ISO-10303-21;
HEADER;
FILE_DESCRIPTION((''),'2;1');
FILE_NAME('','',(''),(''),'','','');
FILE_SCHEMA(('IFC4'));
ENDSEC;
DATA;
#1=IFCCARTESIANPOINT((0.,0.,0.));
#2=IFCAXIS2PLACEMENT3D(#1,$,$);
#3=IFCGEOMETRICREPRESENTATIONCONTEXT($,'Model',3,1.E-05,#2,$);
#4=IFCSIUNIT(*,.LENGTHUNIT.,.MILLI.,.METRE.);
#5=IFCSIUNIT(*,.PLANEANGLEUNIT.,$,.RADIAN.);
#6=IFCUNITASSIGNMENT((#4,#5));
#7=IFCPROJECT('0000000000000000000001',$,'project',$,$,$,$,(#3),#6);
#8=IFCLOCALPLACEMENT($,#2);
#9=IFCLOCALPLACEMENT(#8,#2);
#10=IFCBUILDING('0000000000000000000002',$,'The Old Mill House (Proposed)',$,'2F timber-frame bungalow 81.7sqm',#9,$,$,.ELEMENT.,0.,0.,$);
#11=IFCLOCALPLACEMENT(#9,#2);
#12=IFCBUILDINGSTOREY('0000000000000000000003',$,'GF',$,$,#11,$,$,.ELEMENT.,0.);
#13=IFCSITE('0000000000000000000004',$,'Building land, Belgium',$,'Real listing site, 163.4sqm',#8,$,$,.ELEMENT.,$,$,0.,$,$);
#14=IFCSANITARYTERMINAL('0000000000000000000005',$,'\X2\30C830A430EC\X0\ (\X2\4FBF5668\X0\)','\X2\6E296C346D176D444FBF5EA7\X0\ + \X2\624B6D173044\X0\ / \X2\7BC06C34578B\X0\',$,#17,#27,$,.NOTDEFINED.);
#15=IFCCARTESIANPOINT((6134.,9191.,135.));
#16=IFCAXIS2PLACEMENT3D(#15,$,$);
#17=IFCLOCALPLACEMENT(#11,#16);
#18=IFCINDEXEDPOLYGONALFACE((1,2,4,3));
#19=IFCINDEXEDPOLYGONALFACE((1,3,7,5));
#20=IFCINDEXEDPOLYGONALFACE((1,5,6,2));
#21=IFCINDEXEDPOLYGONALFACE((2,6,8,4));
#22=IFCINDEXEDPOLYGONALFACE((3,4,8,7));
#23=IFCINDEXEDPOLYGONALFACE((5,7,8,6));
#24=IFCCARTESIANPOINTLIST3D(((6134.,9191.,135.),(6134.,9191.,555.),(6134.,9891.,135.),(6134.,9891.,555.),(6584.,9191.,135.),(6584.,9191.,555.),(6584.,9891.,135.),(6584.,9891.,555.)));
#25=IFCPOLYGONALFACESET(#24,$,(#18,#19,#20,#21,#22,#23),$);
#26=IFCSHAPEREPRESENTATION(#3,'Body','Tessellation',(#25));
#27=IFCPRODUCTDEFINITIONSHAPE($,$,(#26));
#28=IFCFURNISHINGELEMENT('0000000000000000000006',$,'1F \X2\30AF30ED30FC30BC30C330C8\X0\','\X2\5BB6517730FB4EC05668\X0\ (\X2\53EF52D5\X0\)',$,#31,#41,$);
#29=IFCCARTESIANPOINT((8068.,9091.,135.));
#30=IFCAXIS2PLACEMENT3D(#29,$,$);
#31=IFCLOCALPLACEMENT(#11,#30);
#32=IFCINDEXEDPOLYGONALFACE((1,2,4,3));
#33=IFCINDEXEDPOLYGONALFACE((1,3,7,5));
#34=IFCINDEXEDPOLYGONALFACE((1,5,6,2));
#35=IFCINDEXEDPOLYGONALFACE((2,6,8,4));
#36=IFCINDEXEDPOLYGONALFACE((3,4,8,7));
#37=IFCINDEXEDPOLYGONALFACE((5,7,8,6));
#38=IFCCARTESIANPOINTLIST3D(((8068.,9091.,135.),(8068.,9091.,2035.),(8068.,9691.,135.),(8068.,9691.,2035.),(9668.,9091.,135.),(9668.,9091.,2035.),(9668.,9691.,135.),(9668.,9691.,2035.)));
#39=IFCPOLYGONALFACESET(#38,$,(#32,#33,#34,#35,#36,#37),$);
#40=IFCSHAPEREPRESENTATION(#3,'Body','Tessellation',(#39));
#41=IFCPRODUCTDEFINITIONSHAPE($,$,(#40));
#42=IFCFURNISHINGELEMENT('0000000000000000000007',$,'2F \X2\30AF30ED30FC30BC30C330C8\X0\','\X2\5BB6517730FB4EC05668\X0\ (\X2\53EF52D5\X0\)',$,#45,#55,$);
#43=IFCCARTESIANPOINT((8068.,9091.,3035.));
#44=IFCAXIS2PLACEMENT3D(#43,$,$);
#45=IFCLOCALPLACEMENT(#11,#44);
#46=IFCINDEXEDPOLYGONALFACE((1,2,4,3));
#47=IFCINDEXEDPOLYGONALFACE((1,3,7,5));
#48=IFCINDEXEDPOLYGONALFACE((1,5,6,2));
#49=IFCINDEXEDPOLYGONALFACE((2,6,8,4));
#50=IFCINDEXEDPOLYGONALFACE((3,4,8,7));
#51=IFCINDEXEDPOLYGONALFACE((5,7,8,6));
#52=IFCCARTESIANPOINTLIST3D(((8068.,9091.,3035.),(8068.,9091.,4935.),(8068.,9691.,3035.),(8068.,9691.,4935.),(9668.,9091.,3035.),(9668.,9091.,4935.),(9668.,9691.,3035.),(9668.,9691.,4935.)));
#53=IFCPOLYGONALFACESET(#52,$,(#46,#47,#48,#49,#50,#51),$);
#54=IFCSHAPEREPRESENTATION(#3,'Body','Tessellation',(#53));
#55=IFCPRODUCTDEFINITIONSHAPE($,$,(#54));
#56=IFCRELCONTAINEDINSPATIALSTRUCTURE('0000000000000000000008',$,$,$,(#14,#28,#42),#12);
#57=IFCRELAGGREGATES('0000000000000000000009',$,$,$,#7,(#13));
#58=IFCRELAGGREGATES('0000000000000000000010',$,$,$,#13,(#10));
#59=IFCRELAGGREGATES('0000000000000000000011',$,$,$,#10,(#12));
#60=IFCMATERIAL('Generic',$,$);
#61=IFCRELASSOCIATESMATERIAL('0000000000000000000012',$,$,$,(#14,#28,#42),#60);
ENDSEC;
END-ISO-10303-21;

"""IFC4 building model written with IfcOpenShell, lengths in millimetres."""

from ifc_helpers import new_model, si_unit, frame, frame_2d, origin, place, context, project, spatial, rectangle, extrude, material, element, save


model = new_model("IFC4")

# Units and contexts
model_context = context("Model", 3, precision=1e-05, world=origin())
ifc_project = project(units=[si_unit("LENGTHUNIT", "METRE", prefix="MILLI"), si_unit("PLANEANGLEUNIT", "RADIAN")], contexts=[model_context])

# Site, building, storey
site_placement = place(None, origin())
site = spatial("IfcSite", under=ifc_project, at=site_placement, Name="Building land, Belgium", ObjectType="Real listing site, 163.4sqm", CompositionType="ELEMENT", RefElevation=0.0)
building_placement = place(site_placement, origin())
building = spatial("IfcBuilding", under=site, at=building_placement, Name="The Old Mill House (Proposed)", ObjectType="2F timber-frame bungalow 81.7sqm", CompositionType="ELEMENT", ElevationOfRefHeight=0.0, ElevationOfTerrain=0.0)
storey_placement = place(building_placement, origin())
storey = spatial("IfcBuildingStorey", under=building, at=storey_placement, Name="GF", CompositionType="ELEMENT", Elevation=0.0)

# Shared definitions
ifc_material_1 = material(Name="Generic")

# Sanitary terminal
sanitary_terminal_1_placement = place(storey_placement, frame((6134.0, 9191.0, 135.0)))
element("IfcSanitaryTerminal", 1, at=sanitary_terminal_1_placement, inside=storey, material=ifc_material_1, Name="トイレ (便器)", Description="温水洗浄便座 + 手洗い / 節水型", PredefinedType="NOTDEFINED", context=model_context, shape_type="SweptSolid", body=[
    extrude(rectangle(XDim=450.0, YDim=700.0, at=frame_2d((225.0, 350.0))), frame((6134.0, 9191.0, 135.0)), (0.0, 0.0, 1.0), 420.0),
])

# Furnishing elements
furnishing_1_placement = place(storey_placement, frame((8068.0, 9091.0, 135.0)))
element("IfcFurnishingElement", 2, at=furnishing_1_placement, inside=storey, material=ifc_material_1, Name="1F クローゼット", Description="家具・什器 (可動)", context=model_context, shape_type="SweptSolid", body=[
    extrude(rectangle(XDim=1600.0, YDim=600.0, at=frame_2d((800.0, 300.0))), frame((8068.0, 9091.0, 135.0)), (0.0, 0.0, 1.0), 1900.0),
])
furnishing_2_placement = place(storey_placement, frame((8068.0, 9091.0, 3035.0)))
element("IfcFurnishingElement", 3, at=furnishing_2_placement, inside=storey, material=ifc_material_1, Name="2F クローゼット", Description="家具・什器 (可動)", context=model_context, shape_type="SweptSolid", body=[
    extrude(rectangle(XDim=1600.0, YDim=600.0, at=frame_2d((800.0, 300.0))), frame((8068.0, 9091.0, 3035.0)), (0.0, 0.0, 1.0), 1900.0),
])

save(model, "model.ifc")
